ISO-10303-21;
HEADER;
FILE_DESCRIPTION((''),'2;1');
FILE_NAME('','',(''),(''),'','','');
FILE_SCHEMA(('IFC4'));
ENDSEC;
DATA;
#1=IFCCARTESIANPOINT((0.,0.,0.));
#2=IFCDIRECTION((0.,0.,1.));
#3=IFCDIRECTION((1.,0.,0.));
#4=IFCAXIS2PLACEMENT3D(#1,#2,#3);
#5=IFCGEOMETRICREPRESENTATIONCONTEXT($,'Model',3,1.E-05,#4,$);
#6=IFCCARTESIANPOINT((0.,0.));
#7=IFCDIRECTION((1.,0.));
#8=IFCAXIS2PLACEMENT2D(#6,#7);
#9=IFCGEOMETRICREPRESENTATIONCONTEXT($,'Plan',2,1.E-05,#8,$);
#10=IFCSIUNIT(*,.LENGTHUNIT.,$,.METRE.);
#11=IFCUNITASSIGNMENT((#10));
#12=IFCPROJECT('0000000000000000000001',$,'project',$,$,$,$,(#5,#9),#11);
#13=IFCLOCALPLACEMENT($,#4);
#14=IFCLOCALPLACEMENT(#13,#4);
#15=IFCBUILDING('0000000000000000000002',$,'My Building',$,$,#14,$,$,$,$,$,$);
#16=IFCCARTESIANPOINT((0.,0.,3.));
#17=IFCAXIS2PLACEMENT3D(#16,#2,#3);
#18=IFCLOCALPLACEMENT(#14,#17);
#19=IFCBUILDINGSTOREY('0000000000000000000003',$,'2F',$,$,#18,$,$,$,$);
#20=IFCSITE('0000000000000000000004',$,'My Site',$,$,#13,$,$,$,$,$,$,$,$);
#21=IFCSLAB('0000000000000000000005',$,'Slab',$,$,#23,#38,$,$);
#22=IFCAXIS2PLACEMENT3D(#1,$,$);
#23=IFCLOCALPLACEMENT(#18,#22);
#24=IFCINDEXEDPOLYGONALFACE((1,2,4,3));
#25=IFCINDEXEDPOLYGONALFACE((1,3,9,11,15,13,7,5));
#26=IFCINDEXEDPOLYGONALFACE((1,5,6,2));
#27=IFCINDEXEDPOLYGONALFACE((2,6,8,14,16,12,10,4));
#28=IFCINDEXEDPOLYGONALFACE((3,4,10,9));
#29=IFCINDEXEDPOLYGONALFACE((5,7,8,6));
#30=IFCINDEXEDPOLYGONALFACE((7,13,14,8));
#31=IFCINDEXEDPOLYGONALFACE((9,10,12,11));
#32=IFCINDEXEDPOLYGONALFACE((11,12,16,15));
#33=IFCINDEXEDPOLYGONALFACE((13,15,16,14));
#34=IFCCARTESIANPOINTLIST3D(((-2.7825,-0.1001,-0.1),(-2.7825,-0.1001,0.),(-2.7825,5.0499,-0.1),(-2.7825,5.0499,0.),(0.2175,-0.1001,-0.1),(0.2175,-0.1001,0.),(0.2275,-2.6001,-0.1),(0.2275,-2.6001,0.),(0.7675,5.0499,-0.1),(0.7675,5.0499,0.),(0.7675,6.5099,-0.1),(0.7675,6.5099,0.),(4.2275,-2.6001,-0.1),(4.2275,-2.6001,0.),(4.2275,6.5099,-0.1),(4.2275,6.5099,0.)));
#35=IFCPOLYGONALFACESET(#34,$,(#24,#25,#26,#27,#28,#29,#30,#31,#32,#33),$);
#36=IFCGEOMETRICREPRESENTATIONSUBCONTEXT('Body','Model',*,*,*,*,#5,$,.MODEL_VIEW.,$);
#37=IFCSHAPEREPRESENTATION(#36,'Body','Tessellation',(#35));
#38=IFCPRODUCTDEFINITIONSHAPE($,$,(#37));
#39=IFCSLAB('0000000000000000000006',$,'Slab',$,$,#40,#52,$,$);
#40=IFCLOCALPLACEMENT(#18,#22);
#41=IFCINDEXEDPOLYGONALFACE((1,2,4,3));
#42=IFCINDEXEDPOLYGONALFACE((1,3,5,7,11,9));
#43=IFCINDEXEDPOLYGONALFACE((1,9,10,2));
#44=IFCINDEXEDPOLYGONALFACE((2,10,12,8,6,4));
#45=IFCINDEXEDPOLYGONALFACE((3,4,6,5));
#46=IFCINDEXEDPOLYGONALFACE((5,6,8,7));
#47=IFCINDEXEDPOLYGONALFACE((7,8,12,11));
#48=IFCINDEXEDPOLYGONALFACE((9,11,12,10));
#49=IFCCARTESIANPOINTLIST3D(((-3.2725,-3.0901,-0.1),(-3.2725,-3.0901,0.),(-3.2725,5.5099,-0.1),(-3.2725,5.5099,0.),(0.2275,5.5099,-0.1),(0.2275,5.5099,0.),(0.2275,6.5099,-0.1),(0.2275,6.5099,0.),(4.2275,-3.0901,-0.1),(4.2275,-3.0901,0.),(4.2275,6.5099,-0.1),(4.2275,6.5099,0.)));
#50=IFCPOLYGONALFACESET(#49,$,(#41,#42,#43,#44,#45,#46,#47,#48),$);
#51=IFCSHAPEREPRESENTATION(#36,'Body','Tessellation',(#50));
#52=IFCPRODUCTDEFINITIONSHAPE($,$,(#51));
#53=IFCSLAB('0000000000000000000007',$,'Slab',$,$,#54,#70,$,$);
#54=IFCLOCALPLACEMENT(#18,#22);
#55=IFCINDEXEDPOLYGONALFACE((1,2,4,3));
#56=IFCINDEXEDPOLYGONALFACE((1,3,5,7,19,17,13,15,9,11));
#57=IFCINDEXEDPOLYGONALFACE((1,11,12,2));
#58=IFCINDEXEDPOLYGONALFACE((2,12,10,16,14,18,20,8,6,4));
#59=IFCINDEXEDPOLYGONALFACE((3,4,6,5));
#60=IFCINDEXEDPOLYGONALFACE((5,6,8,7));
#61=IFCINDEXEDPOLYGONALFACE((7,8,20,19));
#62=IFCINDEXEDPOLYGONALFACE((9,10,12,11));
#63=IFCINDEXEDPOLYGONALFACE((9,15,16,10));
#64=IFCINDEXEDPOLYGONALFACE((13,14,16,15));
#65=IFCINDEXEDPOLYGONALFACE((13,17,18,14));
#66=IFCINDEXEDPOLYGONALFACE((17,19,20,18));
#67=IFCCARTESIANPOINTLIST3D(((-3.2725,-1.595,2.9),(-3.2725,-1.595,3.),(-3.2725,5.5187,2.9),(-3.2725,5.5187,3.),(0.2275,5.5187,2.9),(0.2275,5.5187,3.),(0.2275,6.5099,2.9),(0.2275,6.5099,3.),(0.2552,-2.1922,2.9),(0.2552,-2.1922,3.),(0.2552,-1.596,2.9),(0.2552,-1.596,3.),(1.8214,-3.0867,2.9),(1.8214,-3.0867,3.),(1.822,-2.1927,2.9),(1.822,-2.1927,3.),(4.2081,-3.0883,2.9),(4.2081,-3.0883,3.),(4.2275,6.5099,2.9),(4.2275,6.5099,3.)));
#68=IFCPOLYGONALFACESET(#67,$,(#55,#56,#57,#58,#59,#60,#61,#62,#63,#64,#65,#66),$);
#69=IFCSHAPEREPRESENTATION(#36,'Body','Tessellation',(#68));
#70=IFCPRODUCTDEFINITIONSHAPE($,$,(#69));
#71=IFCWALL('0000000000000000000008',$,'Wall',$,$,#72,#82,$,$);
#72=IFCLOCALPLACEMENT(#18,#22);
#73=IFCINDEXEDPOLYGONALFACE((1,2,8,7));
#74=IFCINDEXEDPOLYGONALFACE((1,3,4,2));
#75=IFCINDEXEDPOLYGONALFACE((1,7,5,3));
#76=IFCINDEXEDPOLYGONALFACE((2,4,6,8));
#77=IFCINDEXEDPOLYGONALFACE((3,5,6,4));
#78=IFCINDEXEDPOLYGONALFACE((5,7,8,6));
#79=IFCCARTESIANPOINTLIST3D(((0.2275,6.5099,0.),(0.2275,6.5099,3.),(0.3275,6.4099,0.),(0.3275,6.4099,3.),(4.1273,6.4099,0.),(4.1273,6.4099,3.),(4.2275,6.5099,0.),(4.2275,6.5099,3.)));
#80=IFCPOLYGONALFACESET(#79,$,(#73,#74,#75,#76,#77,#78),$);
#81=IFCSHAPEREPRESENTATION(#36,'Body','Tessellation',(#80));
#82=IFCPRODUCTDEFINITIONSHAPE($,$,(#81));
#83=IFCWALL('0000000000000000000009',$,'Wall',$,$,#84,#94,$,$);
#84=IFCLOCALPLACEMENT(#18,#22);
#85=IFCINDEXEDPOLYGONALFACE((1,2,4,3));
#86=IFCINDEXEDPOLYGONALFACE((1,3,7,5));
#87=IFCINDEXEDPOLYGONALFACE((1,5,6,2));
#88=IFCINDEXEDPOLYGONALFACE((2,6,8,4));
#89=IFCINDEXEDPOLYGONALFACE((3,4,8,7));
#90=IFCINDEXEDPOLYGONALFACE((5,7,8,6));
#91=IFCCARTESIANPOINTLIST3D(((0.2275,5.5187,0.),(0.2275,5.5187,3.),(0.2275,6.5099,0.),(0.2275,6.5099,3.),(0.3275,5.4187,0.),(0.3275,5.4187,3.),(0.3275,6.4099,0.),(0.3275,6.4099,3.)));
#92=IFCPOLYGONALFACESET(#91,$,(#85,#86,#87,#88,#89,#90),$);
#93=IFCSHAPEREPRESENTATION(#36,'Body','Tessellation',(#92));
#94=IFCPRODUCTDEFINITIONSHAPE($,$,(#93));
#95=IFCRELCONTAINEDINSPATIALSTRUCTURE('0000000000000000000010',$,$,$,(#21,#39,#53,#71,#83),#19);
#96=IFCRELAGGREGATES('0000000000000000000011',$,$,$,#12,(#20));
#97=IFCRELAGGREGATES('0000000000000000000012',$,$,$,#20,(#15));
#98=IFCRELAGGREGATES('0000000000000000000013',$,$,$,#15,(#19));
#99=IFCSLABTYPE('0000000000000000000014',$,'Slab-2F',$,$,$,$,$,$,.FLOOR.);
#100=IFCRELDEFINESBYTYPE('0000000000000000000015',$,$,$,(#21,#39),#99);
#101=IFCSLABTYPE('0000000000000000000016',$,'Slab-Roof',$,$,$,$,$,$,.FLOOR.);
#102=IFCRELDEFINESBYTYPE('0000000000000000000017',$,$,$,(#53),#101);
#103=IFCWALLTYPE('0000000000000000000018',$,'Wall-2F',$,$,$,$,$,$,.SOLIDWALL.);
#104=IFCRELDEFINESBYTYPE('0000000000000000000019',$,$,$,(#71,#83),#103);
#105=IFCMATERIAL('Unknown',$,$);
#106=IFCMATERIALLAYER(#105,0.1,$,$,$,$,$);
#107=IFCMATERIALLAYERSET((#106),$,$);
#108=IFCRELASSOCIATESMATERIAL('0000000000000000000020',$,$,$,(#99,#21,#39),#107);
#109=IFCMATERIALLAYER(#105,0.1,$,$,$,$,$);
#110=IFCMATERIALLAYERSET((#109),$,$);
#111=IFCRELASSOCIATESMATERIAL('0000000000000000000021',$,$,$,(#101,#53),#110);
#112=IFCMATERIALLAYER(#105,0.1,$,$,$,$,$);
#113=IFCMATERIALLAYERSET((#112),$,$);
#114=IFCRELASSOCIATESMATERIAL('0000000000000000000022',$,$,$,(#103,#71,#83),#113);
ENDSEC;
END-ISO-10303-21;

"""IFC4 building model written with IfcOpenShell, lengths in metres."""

from ifc_helpers import new_model, si_unit, frame, origin_with_axes, origin_2d_with_axis, place, context, subcontext, project, spatial, line, indexed_curve, outline, extrude, material, layer, layer_set, layer_usage, type_object, element, save


model = new_model("IFC4")

# Units and contexts
model_context = context("Model", 3, precision=1e-05, world=origin_with_axes())
plan_context = context("Plan", 2, precision=1e-05, world=origin_2d_with_axis())
body_context_1 = subcontext(model_context, "Body", "Model", "MODEL_VIEW")
ifc_project = project(units=[si_unit("LENGTHUNIT", "METRE")], contexts=[model_context, plan_context])

# Site, building, storey
site_placement = place(None, origin_with_axes())
site = spatial("IfcSite", under=ifc_project, at=site_placement, Name="My Site")
building_placement = place(site_placement, origin_with_axes())
building = spatial("IfcBuilding", under=site, at=building_placement, Name="My Building")
storey_placement = place(building_placement, frame((0.0, 0.0, 3.0), z_axis=(0.0, 0.0, 1.0), x_axis=(1.0, 0.0, 0.0)))
storey = spatial("IfcBuildingStorey", under=building, at=storey_placement, Name="2F")

# Slabs
ifc_material = material(Name="Unknown")
ifc_layer_1 = layer(ifc_material, 0.1)
ifc_layer_set_1 = layer_set([ifc_layer_1])
ifc_layer_usage_1 = layer_usage(ifc_layer_set_1, "AXIS3", "POSITIVE", -0.1)
slab_type_1 = type_object("IfcSlabType", Name="Slab-2F", PredefinedType="FLOOR", material=ifc_layer_set_1)
slab_1_placement = place(storey_placement, frame((4.2275, -2.6001, 0.0), z_axis=(0.0, 0.0, 1.0), x_axis=(1.0, 0.0, 0.0)))
element("IfcSlab", 1, at=slab_1_placement, inside=storey, type_object=slab_type_1, material=ifc_layer_usage_1, Name="Slab", context=body_context_1, shape_type="SweptSolid", body=[
    extrude(outline(indexed_curve([(0.0, 0.0), (0.0, 9.11), (-3.46, 9.11), (-3.46, 7.65), (-7.01, 7.65), (-7.01, 2.5), (-4.01, 2.5), (-4.0, 0.0), (0.0, 0.0)])), frame((0.0, 0.0, -0.1), z_axis=(0.0, 0.0, 1.0), x_axis=(1.0, 0.0, 0.0)), (0.0, 0.0, 1.0), 0.1),
])
ifc_layer_usage_2 = layer_usage(ifc_layer_set_1, "AXIS3", "POSITIVE", -0.1)
slab_2_placement = place(storey_placement, frame((4.2275, 6.5099, 0.0), z_axis=(0.0, 0.0, 1.0), x_axis=(1.0, 0.0, 0.0)))
element("IfcSlab", 2, at=slab_2_placement, inside=storey, type_object=slab_type_1, material=ifc_layer_usage_2, Name="Slab", context=body_context_1, shape_type="SweptSolid", body=[
    extrude(outline(indexed_curve([(0.0, 0.0), (-4.0, 0.0), (-4.0, -1.0), (-7.5, -1.0), (-7.5, -9.6), (0.0, -9.6), (0.0, 0.0)])), frame((0.0, 0.0, -0.1), z_axis=(0.0, 0.0, 1.0), x_axis=(1.0, 0.0, 0.0)), (0.0, 0.0, 1.0), 0.1),
])
ifc_layer_2 = layer(ifc_material, 0.1)
ifc_layer_set_2 = layer_set([ifc_layer_2])
ifc_layer_usage_3 = layer_usage(ifc_layer_set_2, "AXIS3", "POSITIVE", -0.1)
slab_type_2 = type_object("IfcSlabType", Name="Slab-Roof", PredefinedType="FLOOR", material=ifc_layer_set_2)
slab_3_placement = place(storey_placement, frame((4.2275, 6.5099, 3.0), z_axis=(0.0, 0.0, 1.0), x_axis=(1.0, 0.0, 0.0)))
element("IfcSlab", 3, at=slab_3_placement, inside=storey, type_object=slab_type_2, material=ifc_layer_usage_3, Name="Slab", context=body_context_1, shape_type="SweptSolid", body=[
    extrude(outline(indexed_curve([(0.0, 0.0), (-4.0, 0.0), (-4.0, -0.9913), (-7.5, -0.9913), (-7.5, -8.1049), (-3.9723, -8.1059), (-3.9723, -8.7022), (-2.4055, -8.7026), (-2.4061, -9.5967), (-0.0194, -9.5982), (0.0, 0.0)])), frame((0.0, 0.0, -0.1), z_axis=(0.0, 0.0, 1.0), x_axis=(1.0, 0.0, 0.0)), (0.0, 0.0, 1.0), 0.1),
])

# Walls
ifc_layer_3 = layer(ifc_material, 0.1)
ifc_layer_set_3 = layer_set([ifc_layer_3])
ifc_layer_usage_4 = layer_usage(ifc_layer_set_3, "AXIS2", "POSITIVE", 0.0)
wall_type = type_object("IfcWallType", Name="Wall-2F", PredefinedType="SOLIDWALL", material=ifc_layer_set_3)
wall_1_placement = place(storey_placement, frame((4.2275, 6.5099, 0.0), z_axis=(0.0, 0.0, 1.0), x_axis=(-1.0, 0.0, 0.0)))
element("IfcWall", 4, at=wall_1_placement, inside=storey, type_object=wall_type, material=ifc_layer_usage_4, Name="Wall", context=body_context_1, shape_type="SweptSolid", body=[
    extrude(outline(indexed_curve([(0.0, 0.0), (0.1002, 0.1), (3.9, 0.1), (4.0, 0.0)], segments=[line(1, 2, 3, 4, 1)])), origin_with_axes(), (0.0, 0.0, 1.0), 3.0),
])
ifc_layer_usage_5 = layer_usage(ifc_layer_set_3, "AXIS2", "POSITIVE", 0.0)
wall_2_placement = place(storey_placement, frame((0.2275, 6.5099, 0.0), z_axis=(0.0, 0.0, 1.0), x_axis=(0.0, -1.0, 0.0)))
element("IfcWall", 5, at=wall_2_placement, inside=storey, type_object=wall_type, material=ifc_layer_usage_5, Name="Wall", context=body_context_1, shape_type="SweptSolid", body=[
    extrude(outline(indexed_curve([(0.0, 0.0), (0.1, 0.1), (1.0913, 0.1), (0.9913, 0.0)], segments=[line(1, 2, 3, 4, 1)])), origin_with_axes(), (0.0, 0.0, 1.0), 3.0),
])

save(model, "model.ifc")
